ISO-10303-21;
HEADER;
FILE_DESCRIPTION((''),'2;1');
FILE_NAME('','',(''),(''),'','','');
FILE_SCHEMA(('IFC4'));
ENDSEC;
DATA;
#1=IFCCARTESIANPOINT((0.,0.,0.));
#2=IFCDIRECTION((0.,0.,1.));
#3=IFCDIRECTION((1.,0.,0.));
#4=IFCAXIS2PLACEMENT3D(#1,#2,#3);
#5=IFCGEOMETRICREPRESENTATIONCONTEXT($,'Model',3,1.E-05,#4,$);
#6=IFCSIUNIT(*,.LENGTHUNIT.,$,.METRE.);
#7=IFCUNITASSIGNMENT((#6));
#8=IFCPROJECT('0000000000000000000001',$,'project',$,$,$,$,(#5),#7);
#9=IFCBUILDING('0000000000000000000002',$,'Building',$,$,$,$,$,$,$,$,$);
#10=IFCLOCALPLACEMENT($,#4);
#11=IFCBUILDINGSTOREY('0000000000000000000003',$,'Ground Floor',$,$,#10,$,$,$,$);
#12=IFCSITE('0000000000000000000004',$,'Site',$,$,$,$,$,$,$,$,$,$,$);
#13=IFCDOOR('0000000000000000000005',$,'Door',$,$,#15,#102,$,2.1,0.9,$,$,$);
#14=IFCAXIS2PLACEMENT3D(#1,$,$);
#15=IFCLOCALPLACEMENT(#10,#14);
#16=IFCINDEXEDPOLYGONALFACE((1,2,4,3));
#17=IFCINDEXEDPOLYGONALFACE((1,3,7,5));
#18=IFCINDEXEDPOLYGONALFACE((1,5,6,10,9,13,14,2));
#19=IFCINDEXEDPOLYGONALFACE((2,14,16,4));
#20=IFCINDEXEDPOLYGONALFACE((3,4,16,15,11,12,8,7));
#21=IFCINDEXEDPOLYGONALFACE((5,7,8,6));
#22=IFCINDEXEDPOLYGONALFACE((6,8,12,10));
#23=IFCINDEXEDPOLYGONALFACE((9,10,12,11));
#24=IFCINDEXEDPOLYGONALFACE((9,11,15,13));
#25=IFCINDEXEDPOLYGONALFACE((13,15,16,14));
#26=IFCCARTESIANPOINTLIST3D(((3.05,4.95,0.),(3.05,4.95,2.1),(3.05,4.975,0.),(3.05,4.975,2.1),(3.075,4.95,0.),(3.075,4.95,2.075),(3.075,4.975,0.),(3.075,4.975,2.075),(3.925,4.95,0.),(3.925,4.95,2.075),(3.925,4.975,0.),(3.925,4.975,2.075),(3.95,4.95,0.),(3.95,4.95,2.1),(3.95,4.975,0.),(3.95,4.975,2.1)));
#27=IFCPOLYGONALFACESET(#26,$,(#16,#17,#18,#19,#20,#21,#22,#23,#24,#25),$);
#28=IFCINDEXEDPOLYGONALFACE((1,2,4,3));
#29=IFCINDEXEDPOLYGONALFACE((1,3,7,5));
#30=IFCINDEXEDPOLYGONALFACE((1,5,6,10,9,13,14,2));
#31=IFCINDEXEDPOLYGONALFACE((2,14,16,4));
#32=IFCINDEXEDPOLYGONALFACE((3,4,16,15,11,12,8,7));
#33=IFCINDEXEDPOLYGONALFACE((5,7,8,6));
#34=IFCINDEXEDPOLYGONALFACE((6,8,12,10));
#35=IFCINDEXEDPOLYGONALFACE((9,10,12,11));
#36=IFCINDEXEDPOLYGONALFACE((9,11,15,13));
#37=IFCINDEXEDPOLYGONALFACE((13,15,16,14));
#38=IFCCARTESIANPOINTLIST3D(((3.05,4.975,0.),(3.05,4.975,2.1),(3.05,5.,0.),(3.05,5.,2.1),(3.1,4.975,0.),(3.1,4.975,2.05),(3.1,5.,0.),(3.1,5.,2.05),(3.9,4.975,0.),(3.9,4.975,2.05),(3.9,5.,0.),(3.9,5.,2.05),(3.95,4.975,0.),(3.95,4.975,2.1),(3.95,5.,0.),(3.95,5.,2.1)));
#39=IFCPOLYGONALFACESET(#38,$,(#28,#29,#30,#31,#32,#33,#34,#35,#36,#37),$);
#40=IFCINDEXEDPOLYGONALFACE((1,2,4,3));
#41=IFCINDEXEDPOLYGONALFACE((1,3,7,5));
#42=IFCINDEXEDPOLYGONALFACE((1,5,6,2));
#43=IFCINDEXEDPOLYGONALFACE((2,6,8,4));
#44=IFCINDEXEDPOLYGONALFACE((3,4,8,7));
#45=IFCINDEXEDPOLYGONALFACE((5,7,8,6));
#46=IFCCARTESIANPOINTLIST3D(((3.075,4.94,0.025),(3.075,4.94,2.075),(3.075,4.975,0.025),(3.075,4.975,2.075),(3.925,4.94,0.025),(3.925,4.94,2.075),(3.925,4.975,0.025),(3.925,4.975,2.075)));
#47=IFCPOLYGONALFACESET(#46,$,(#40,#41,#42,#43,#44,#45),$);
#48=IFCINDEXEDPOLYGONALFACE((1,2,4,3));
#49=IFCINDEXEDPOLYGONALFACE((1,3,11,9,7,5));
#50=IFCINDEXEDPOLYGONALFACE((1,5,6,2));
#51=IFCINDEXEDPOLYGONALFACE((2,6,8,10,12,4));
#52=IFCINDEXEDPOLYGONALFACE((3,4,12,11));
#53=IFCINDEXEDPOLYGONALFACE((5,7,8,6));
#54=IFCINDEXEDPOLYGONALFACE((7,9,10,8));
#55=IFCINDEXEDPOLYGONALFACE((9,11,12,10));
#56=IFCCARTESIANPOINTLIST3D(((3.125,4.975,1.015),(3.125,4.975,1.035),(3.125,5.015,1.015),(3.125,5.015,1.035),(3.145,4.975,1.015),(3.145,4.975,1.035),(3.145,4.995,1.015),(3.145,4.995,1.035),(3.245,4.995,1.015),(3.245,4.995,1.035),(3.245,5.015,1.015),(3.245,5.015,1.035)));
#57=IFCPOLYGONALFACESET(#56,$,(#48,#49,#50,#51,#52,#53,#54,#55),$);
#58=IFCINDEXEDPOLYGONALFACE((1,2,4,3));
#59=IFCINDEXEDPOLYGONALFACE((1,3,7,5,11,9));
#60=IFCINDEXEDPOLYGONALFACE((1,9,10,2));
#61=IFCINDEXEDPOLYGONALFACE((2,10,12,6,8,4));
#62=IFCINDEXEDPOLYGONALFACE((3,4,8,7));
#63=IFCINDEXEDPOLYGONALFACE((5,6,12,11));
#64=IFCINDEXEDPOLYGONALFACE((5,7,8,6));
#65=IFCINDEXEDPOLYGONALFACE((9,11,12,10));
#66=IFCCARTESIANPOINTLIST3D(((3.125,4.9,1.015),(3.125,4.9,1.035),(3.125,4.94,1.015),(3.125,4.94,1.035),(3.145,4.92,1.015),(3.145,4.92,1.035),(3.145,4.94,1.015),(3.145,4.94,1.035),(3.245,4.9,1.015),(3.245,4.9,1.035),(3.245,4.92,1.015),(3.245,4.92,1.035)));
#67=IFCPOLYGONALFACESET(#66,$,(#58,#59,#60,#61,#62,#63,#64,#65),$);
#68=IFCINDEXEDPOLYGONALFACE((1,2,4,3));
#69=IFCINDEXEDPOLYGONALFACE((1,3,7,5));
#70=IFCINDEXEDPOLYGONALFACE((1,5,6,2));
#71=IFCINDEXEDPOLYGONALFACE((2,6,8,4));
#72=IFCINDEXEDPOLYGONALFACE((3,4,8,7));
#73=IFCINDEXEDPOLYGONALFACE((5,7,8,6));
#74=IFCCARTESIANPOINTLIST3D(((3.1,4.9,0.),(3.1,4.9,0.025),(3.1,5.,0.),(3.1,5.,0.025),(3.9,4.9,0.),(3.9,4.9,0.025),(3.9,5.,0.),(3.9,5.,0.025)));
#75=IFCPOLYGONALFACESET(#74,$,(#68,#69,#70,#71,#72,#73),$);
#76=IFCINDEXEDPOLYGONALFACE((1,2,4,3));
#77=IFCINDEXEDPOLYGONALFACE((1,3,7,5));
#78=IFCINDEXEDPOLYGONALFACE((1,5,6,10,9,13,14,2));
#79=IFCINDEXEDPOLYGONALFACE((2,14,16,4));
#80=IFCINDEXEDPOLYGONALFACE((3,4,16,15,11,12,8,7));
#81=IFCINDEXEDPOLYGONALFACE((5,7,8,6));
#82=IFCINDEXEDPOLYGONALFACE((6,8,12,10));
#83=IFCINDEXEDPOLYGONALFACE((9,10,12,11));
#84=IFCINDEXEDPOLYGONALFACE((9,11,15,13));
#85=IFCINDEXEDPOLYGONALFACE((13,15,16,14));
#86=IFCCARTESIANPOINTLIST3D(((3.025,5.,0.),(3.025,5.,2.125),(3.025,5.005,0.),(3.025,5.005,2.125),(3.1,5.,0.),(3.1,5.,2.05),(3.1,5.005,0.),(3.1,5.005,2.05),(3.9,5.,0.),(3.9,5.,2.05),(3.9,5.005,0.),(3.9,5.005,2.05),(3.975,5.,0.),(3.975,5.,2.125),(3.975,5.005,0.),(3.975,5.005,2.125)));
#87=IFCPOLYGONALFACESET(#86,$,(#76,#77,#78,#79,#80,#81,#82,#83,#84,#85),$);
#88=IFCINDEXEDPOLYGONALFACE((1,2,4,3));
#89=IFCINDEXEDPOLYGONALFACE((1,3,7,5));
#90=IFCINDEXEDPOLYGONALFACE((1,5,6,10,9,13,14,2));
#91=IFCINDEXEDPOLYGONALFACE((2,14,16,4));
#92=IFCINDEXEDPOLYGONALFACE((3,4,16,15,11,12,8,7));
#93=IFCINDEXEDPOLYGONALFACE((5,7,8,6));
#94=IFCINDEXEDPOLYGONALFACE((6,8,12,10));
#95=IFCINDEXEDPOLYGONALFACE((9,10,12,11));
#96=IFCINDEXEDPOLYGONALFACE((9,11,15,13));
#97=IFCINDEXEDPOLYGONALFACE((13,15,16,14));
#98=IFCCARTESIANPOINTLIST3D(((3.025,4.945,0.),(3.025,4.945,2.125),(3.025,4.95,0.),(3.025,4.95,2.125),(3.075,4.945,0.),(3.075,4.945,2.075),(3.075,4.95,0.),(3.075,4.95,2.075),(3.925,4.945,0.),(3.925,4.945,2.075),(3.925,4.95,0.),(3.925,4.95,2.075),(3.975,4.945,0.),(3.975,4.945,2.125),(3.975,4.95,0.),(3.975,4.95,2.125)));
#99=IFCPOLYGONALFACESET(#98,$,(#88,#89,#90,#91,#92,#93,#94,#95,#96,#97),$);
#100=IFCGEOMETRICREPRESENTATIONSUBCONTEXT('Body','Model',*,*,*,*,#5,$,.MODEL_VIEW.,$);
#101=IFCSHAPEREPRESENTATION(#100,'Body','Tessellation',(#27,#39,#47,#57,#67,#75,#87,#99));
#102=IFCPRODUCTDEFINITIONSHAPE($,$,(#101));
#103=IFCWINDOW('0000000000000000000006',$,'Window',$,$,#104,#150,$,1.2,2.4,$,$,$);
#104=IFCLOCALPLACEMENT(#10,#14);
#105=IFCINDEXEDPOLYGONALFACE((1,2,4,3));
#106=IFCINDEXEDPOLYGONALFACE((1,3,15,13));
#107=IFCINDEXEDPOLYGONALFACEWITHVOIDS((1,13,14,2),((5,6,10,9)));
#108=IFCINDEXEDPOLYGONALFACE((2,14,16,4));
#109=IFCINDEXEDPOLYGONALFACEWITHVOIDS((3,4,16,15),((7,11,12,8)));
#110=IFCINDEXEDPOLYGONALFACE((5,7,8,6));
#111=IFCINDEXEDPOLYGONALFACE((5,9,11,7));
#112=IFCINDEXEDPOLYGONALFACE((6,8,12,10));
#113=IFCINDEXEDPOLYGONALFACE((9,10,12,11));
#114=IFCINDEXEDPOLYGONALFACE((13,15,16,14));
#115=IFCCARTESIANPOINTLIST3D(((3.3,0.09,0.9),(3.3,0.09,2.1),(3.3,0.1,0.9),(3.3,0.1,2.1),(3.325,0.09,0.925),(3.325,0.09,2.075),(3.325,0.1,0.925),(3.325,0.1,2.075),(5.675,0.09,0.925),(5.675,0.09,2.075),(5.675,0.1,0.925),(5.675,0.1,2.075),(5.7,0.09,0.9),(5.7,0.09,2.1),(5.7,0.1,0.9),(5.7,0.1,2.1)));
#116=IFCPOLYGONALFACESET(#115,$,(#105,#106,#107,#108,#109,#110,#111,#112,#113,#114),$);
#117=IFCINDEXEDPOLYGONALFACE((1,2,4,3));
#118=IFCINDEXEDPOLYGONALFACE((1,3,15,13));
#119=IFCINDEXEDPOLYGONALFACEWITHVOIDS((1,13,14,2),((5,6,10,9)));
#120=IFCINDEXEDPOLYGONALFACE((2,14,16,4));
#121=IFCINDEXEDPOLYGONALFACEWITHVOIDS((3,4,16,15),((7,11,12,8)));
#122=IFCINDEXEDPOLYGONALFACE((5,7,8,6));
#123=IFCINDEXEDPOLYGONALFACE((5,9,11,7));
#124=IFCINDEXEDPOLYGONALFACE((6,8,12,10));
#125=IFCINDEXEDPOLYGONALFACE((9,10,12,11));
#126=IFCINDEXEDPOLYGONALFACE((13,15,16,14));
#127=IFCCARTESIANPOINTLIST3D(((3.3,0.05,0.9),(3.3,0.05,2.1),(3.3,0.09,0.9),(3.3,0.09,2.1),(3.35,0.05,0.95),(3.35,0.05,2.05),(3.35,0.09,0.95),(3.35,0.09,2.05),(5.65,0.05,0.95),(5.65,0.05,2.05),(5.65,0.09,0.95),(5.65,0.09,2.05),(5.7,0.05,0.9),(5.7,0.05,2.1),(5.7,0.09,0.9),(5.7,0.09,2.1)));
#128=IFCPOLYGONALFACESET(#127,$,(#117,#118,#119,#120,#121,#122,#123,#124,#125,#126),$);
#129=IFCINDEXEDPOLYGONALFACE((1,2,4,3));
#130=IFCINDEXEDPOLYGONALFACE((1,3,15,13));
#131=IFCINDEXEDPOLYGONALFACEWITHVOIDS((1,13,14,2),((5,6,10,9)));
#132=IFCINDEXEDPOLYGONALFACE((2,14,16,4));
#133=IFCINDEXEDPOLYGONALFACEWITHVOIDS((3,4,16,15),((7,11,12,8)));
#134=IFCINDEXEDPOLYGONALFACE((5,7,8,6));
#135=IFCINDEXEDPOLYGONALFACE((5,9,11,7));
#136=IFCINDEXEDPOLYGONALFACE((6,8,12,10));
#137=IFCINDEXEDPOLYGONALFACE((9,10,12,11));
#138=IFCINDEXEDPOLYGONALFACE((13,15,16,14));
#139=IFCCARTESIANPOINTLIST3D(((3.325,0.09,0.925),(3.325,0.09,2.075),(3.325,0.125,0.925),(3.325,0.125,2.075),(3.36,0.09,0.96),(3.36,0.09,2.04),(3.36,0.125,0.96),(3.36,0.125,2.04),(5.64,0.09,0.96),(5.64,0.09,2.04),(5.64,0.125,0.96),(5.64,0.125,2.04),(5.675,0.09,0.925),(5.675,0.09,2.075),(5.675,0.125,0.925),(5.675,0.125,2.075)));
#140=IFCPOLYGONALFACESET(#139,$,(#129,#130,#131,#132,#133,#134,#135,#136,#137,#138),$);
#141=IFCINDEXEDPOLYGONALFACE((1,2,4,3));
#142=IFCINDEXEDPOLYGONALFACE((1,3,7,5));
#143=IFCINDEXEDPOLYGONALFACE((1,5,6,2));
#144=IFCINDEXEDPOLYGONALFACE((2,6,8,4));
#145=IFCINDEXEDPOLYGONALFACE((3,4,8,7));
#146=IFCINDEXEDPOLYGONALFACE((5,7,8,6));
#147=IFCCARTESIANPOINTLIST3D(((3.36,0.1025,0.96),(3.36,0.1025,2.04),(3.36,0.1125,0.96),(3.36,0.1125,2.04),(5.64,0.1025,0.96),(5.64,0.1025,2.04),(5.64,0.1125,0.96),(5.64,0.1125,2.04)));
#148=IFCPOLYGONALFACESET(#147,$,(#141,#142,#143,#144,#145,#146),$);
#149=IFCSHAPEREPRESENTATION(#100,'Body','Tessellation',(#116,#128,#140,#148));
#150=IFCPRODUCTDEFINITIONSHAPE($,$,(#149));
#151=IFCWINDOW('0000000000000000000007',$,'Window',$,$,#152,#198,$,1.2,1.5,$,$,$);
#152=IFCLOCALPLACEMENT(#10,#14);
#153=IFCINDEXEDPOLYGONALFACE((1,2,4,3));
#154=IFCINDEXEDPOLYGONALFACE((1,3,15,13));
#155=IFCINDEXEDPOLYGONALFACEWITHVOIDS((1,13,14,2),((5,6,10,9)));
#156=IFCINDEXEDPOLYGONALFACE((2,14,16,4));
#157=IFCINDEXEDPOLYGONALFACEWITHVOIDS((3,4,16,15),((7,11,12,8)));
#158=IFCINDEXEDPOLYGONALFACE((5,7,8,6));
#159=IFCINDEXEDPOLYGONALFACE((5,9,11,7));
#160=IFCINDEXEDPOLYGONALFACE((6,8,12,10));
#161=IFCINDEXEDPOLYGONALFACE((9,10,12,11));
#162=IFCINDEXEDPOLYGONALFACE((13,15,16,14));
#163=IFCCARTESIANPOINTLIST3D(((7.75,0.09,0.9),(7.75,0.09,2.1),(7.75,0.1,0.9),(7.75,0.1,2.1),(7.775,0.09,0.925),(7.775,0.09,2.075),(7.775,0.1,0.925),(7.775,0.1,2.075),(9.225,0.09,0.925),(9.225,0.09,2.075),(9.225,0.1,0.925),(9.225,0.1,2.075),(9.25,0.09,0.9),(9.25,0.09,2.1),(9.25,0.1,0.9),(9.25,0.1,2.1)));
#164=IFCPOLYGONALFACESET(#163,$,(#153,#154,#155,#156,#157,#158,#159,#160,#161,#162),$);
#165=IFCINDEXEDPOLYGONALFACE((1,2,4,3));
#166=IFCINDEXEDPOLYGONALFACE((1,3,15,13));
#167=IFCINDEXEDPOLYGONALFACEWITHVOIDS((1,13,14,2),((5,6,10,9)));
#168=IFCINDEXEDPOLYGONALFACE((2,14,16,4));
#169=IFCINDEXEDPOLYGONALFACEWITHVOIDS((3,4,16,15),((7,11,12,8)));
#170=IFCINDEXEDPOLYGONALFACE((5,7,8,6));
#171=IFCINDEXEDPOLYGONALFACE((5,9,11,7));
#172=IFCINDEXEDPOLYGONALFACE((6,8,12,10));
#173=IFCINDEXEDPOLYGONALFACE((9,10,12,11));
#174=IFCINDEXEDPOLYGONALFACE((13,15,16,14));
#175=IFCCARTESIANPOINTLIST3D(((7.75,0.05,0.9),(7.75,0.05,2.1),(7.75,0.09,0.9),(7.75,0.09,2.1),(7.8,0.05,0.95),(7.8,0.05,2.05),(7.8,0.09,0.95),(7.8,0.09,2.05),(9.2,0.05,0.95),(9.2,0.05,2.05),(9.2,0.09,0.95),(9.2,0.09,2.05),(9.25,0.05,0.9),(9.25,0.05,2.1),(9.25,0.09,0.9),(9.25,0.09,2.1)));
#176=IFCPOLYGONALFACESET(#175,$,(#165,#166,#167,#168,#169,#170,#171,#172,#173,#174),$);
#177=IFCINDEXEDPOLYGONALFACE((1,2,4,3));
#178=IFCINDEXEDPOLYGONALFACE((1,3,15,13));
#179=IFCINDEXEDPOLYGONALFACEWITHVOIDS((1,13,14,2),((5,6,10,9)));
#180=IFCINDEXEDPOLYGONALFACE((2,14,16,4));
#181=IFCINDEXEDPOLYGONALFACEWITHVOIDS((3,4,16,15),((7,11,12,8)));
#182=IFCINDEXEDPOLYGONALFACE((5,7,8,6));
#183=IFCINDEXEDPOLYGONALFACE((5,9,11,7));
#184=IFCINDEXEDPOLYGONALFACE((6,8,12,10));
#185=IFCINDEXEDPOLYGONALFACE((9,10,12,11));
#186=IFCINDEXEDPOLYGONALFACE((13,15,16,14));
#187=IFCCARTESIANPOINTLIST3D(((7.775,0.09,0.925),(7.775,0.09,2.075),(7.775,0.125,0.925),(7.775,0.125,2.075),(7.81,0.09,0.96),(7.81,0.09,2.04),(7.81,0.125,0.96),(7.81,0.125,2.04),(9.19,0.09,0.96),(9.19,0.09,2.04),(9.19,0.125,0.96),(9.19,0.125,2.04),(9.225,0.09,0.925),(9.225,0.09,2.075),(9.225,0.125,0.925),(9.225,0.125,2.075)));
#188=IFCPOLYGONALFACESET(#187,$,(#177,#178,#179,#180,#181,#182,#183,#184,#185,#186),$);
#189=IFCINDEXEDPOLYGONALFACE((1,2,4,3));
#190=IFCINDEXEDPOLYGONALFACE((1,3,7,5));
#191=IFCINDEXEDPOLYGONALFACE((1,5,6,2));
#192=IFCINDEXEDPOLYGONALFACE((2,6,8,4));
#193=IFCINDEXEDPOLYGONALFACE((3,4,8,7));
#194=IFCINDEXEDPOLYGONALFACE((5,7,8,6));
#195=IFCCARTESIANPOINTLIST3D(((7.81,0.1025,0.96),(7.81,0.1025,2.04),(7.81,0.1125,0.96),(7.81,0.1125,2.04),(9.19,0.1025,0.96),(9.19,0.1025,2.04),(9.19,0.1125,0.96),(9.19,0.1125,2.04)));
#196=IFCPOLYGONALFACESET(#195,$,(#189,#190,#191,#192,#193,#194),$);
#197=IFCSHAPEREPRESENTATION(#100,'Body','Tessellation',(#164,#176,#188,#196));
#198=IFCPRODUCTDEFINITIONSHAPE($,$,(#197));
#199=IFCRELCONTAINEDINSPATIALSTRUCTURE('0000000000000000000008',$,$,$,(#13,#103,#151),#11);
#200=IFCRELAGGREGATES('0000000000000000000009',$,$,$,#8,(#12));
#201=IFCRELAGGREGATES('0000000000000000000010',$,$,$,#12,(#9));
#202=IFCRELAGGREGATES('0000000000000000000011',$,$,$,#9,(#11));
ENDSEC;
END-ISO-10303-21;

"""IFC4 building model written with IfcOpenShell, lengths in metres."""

from ifc_helpers import new_model, si_unit, frame, origin_with_axes, place, context, subcontext, project, spatial, line, indexed_curve, outline, extrude, element, save


model = new_model("IFC4")

# Units and contexts
model_context = context("Model", 3, precision=1e-05, world=origin_with_axes())
body_context = subcontext(model_context, "Body", "Model", "MODEL_VIEW")
ifc_project = project(units=[si_unit("LENGTHUNIT", "METRE")], contexts=[model_context])

# Site, building, storey
site = spatial("IfcSite", under=ifc_project, Name="Site")
building = spatial("IfcBuilding", under=site, Name="Building")
storey_placement = place(None, origin_with_axes())
storey = spatial("IfcBuildingStorey", under=building, at=storey_placement, Name="Ground Floor")

# Door
door_1_placement = place(storey_placement, frame((3.95, 5.0, 0.0), z_axis=(0.0, 0.0, 1.0), x_axis=(-1.0, 0.0, 0.0)))
element("IfcDoor", 1, at=door_1_placement, inside=storey, Name="Door", OverallHeight=2.1, OverallWidth=0.9, context=body_context, shape_type="SweptSolid", body=[
    extrude(outline(indexed_curve([(0.0, 0.0), (0.0, 2.1), (0.9, 2.1), (0.9, 0.0), (0.875, 0.0), (0.875, 2.075), (0.025, 2.075), (0.025, 0.0)], segments=[line(1, 2, 3, 4, 5, 6, 7, 8, 1)])), frame((0.0, 0.025, 0.0), z_axis=(0.0, -1.0, 0.0), x_axis=(1.0, 0.0, 0.0)), (0.0, 0.0, -1.0), 0.025),
    extrude(outline(indexed_curve([(0.0, 0.0), (0.0, 2.1), (0.9, 2.1), (0.9, 0.0), (0.85, 0.0), (0.85, 2.05), (0.05, 2.05), (0.05, 0.0)], segments=[line(1, 2, 3, 4, 5, 6, 7, 8, 1)])), frame((0.0, 0.0, 0.0), z_axis=(0.0, -1.0, 0.0), x_axis=(1.0, 0.0, 0.0)), (0.0, 0.0, -1.0), 0.025),
    extrude(outline(indexed_curve([(0.0, 0.0), (0.85, 0.0), (0.85, 0.035), (0.0, 0.035)], segments=[line(1, 2, 3, 4, 1)])), frame((0.025, 0.025, 0.025), z_axis=(0.0, 0.0, 1.0), x_axis=(1.0, 0.0, 0.0)), (0.0, 0.0, 1.0), 2.05),
    extrude(outline(indexed_curve([(0.0, 0.0), (0.0, -0.04), (-0.12, -0.04), (-0.12, -0.02), (-0.02, -0.02), (-0.02, 0.0)], segments=[line(1, 2, 3, 4, 5, 6, 1)])), frame((0.825, 0.025, 1.015), z_axis=(0.0, 0.0, 1.0), x_axis=(1.0, 0.0, 0.0)), (0.0, 0.0, 1.0), 0.02),
    extrude(outline(indexed_curve([(0.0, 0.0), (0.0, 0.04), (-0.12, 0.04), (-0.12, 0.02), (-0.02, 0.02), (-0.02, 0.0)], segments=[line(1, 2, 3, 4, 5, 6, 1)])), frame((0.825, 0.06, 1.015), z_axis=(0.0, 0.0, 1.0), x_axis=(1.0, 0.0, 0.0)), (0.0, 0.0, 1.0), 0.02),
    extrude(outline(indexed_curve([(0.0, 0.0), (0.8, 0.0), (0.8, 0.1), (0.0, 0.1)], segments=[line(1, 2, 3, 4, 1)])), frame((0.05, 0.0, 0.0), z_axis=(0.0, 0.0, 1.0), x_axis=(1.0, 0.0, 0.0)), (0.0, 0.0, 1.0), 0.025),
    extrude(outline(indexed_curve([(0.0, 0.0), (0.0, 2.125), (0.95, 2.125), (0.95, 0.0), (0.875, 0.0), (0.875, 2.05), (0.075, 2.05), (0.075, 0.0)], segments=[line(1, 2, 3, 4, 5, 6, 7, 8, 1)])), frame((-0.025, -0.005, 0.0), z_axis=(0.0, -1.0, 0.0), x_axis=(1.0, 0.0, 0.0)), (0.0, 0.0, -1.0), 0.005),
    extrude(outline(indexed_curve([(0.0, 0.0), (0.0, 2.125), (0.95, 2.125), (0.95, 0.0), (0.9, 0.0), (0.9, 2.075), (0.05, 2.075), (0.05, 0.0)], segments=[line(1, 2, 3, 4, 5, 6, 7, 8, 1)])), frame((-0.025, 0.05, 0.0), z_axis=(0.0, -1.0, 0.0), x_axis=(1.0, 0.0, 0.0)), (0.0, 0.0, -1.0), 0.005),
])

# Windows
window_1_placement = place(storey_placement, frame((3.3, 0.0, 0.9), z_axis=(0.0, 0.0, 1.0), x_axis=(1.0, 0.0, 0.0)))
element("IfcWindow", 2, at=window_1_placement, inside=storey, Name="Window", OverallHeight=1.2, OverallWidth=2.4, context=body_context, shape_type="SweptSolid", body=[
    extrude(outline(indexed_curve([(0.0, 0.0), (2.4, 0.0), (2.4, 1.2), (0.0, 1.2)], segments=[line(1, 2, 3, 4, 1)]), holes=[indexed_curve([(0.025, 0.025), (2.375, 0.025), (2.375, 1.175), (0.025, 1.175)], segments=[line(1, 2, 3, 4, 1)])]), frame((0.0, 0.09, 0.0), z_axis=(0.0, -1.0, 0.0), x_axis=(1.0, 0.0, 0.0)), (0.0, 0.0, -1.0), 0.01),
    extrude(outline(indexed_curve([(0.0, 0.0), (2.4, 0.0), (2.4, 1.2), (0.0, 1.2)], segments=[line(1, 2, 3, 4, 1)]), holes=[indexed_curve([(0.05, 0.05), (2.35, 0.05), (2.35, 1.15), (0.05, 1.15)], segments=[line(1, 2, 3, 4, 1)])]), frame((0.0, 0.05, 0.0), z_axis=(0.0, -1.0, 0.0), x_axis=(1.0, 0.0, 0.0)), (0.0, 0.0, -1.0), 0.04),
    extrude(outline(indexed_curve([(0.0, 0.0), (2.35, 0.0), (2.35, 1.15), (0.0, 1.15)], segments=[line(1, 2, 3, 4, 1)]), holes=[indexed_curve([(0.035, 0.035), (2.315, 0.035), (2.315, 1.115), (0.035, 1.115)], segments=[line(1, 2, 3, 4, 1)])]), frame((0.025, 0.09, 0.025), z_axis=(0.0, -1.0, 0.0), x_axis=(1.0, 0.0, 0.0)), (0.0, 0.0, -1.0), 0.035),
    extrude(outline(indexed_curve([(0.035, 0.035), (2.315, 0.035), (2.315, 1.115), (0.035, 1.115)], segments=[line(1, 2, 3, 4, 1)])), frame((0.025, 0.1025, 0.025), z_axis=(0.0, -1.0, 0.0), x_axis=(1.0, 0.0, 0.0)), (0.0, 0.0, -1.0), 0.01),
])
window_2_placement = place(storey_placement, frame((7.75, 0.0, 0.9), z_axis=(0.0, 0.0, 1.0), x_axis=(1.0, 0.0, 0.0)))
element("IfcWindow", 3, at=window_2_placement, inside=storey, Name="Window", OverallHeight=1.2, OverallWidth=1.5, context=body_context, shape_type="SweptSolid", body=[
    extrude(outline(indexed_curve([(0.0, 0.0), (1.5, 0.0), (1.5, 1.2), (0.0, 1.2)], segments=[line(1, 2, 3, 4, 1)]), holes=[indexed_curve([(0.025, 0.025), (1.475, 0.025), (1.475, 1.175), (0.025, 1.175)], segments=[line(1, 2, 3, 4, 1)])]), frame((0.0, 0.09, 0.0), z_axis=(0.0, -1.0, 0.0), x_axis=(1.0, 0.0, 0.0)), (0.0, 0.0, -1.0), 0.01),
    extrude(outline(indexed_curve([(0.0, 0.0), (1.5, 0.0), (1.5, 1.2), (0.0, 1.2)], segments=[line(1, 2, 3, 4, 1)]), holes=[indexed_curve([(0.05, 0.05), (1.45, 0.05), (1.45, 1.15), (0.05, 1.15)], segments=[line(1, 2, 3, 4, 1)])]), frame((0.0, 0.05, 0.0), z_axis=(0.0, -1.0, 0.0), x_axis=(1.0, 0.0, 0.0)), (0.0, 0.0, -1.0), 0.04),
    extrude(outline(indexed_curve([(0.0, 0.0), (1.45, 0.0), (1.45, 1.15), (0.0, 1.15)], segments=[line(1, 2, 3, 4, 1)]), holes=[indexed_curve([(0.035, 0.035), (1.415, 0.035), (1.415, 1.115), (0.035, 1.115)], segments=[line(1, 2, 3, 4, 1)])]), frame((0.025, 0.09, 0.025), z_axis=(0.0, -1.0, 0.0), x_axis=(1.0, 0.0, 0.0)), (0.0, 0.0, -1.0), 0.035),
    extrude(outline(indexed_curve([(0.035, 0.035), (1.415, 0.035), (1.415, 1.115), (0.035, 1.115)], segments=[line(1, 2, 3, 4, 1)])), frame((0.025, 0.1025, 0.025), z_axis=(0.0, -1.0, 0.0), x_axis=(1.0, 0.0, 0.0)), (0.0, 0.0, -1.0), 0.01),
])

save(model, "model.ifc")
